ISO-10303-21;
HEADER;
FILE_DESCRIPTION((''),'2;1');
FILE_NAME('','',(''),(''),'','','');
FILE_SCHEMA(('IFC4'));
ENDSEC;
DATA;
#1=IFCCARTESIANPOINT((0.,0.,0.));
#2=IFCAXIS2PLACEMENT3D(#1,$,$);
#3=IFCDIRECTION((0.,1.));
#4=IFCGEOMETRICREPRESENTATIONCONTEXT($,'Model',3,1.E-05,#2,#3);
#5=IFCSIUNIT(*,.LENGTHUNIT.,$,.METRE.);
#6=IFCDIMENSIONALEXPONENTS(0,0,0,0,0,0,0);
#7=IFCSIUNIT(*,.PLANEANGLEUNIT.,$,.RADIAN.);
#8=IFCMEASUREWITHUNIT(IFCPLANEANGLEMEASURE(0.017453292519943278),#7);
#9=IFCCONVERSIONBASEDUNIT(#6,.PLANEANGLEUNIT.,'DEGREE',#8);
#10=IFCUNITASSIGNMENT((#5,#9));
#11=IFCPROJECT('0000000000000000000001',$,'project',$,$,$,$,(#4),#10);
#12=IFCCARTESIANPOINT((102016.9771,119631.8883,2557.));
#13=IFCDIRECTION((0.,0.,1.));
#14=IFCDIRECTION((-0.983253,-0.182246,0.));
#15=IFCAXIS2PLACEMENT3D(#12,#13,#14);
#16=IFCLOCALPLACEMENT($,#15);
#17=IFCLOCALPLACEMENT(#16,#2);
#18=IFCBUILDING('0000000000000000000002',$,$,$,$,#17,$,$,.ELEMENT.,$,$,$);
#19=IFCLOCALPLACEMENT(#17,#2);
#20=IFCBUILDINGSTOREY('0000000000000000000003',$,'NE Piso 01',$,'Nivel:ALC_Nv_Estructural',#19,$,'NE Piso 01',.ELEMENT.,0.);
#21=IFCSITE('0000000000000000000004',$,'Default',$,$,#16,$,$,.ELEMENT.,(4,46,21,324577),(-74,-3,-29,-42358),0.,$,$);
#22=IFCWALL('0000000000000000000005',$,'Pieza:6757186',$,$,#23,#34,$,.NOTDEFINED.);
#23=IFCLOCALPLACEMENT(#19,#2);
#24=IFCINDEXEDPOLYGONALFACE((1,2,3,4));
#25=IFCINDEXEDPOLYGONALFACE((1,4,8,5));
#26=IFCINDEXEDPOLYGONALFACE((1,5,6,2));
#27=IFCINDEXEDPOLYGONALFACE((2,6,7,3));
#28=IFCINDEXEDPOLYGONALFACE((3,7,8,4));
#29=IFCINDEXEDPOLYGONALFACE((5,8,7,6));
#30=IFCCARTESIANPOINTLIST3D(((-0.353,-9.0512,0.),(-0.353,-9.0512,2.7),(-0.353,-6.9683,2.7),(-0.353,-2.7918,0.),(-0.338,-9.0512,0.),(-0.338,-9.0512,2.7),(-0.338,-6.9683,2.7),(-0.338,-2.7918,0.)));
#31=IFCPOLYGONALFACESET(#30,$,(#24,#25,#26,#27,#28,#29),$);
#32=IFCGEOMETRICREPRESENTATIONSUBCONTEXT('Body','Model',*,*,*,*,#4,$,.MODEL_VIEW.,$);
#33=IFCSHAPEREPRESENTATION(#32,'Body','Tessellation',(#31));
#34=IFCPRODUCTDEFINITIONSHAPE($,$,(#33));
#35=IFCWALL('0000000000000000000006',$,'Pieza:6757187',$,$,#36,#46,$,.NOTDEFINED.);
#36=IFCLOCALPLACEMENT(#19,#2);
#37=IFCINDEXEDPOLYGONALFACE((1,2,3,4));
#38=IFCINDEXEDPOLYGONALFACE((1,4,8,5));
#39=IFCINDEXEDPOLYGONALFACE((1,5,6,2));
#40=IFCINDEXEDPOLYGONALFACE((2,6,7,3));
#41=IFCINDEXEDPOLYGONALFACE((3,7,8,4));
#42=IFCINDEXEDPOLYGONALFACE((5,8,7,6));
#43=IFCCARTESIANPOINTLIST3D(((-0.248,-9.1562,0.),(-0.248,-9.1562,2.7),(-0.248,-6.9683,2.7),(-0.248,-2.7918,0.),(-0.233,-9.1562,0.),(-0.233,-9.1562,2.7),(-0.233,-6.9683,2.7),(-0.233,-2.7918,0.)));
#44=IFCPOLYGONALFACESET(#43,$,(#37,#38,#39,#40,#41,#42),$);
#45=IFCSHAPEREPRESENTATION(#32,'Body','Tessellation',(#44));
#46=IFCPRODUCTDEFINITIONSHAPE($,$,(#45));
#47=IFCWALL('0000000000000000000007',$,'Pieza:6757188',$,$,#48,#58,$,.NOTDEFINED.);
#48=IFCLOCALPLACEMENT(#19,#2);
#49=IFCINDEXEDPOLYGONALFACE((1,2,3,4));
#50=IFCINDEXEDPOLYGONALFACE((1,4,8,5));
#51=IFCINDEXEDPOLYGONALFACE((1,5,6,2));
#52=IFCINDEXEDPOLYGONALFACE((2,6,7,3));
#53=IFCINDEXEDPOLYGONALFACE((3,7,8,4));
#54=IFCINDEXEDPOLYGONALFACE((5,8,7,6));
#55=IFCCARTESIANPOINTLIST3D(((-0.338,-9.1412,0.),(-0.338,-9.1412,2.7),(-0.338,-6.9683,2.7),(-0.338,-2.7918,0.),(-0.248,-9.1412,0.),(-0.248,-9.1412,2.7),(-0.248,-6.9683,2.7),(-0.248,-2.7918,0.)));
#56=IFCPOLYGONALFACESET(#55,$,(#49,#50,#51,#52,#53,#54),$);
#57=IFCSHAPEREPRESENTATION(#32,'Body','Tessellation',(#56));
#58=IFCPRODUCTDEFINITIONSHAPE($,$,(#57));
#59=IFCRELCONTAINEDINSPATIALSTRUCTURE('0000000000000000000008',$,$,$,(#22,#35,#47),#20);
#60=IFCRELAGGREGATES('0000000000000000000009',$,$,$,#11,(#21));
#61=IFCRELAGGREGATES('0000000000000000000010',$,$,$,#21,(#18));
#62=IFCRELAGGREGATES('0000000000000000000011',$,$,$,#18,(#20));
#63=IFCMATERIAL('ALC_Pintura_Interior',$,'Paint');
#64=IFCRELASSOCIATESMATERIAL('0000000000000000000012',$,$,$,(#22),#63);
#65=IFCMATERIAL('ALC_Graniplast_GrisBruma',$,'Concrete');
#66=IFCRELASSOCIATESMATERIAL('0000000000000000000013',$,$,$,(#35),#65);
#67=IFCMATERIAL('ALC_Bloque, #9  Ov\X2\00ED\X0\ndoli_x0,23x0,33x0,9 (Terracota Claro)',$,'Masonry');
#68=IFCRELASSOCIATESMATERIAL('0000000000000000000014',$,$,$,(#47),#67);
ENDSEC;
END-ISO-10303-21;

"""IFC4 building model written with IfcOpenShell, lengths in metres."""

from ifc_helpers import new_model, entity, si_unit, converted_unit, direction, frame, frame_2d, origin, origin_2d_with_axis, place, context, subcontext, project, spatial, rectangle, extrude, clip, halfspace, material, element, save


model = new_model("IFC4")

# Units and contexts
model_context = context("Model", 3, precision=1e-05, world=origin(), true_north=direction((0.0, 1.0)))
body_context = subcontext(model_context, "Body", "Model", "MODEL_VIEW")
ifc_project = project(units=[si_unit("LENGTHUNIT", "METRE"), converted_unit("PLANEANGLEUNIT", "DEGREE", entity("IfcPlaneAngleMeasure", 0.017453292519943278), si_unit("PLANEANGLEUNIT", "RADIAN"), dimensions=[0, 0, 0, 0, 0, 0, 0])], contexts=[model_context])

# Site, building, storey
site_placement = place(None, frame((102016.9771, 119631.8883, 2557.0), z_axis=(0.0, 0.0, 1.0), x_axis=(-0.983253, -0.182246, 0.0)))
site = spatial("IfcSite", under=ifc_project, at=site_placement, Name="Default", CompositionType="ELEMENT", RefLatitude=(4, 46, 21, 324577), RefLongitude=(-74, -3, -29, -42358), RefElevation=0.0)
building_placement = place(site_placement, origin())
building = spatial("IfcBuilding", under=site, at=building_placement, CompositionType="ELEMENT")
storey_placement = place(building_placement, origin())
storey = spatial("IfcBuildingStorey", under=building, at=storey_placement, Name="NE Piso 01", ObjectType="Nivel:ALC_Nv_Estructural", LongName="NE Piso 01", CompositionType="ELEMENT", Elevation=0.0)

# Shared definitions
ifc_material_1 = material(Name="ALC_Pintura_Interior", Category="Paint")

# Shared definitions
ifc_material_2 = material(Name="ALC_Bloque, #9  Ovíndoli_x0,23x0,33x0,9 (Terracota Claro)", Category="Masonry")

# Walls
ifc_material_3 = material(Name="ALC_Graniplast_GrisBruma", Category="Concrete")
wall_1_placement = place(storey_placement, origin())
element("IfcWall", 1, at=wall_1_placement, inside=storey, material=ifc_material_1, Name="Pieza:6757186", PredefinedType="NOTDEFINED", context=body_context, shape_type="SweptSolid", body=[
    clip(extrude(rectangle(XDim=0.015, YDim=6.2594, at=frame_2d((0.0, 0.0), x_axis=(1.0, 0.0))), frame((-0.3455, -5.9215, 0.0)), (0.0, 0.0, 1.0), 2.7), halfspace(frame((-0.233, -2.7918, 0.0), z_axis=(0.0, 0.5429, 0.839798), x_axis=(-1.0, 0.0, 0.0)), False)),
])
wall_2_placement = place(storey_placement, origin())
element("IfcWall", 2, at=wall_2_placement, inside=storey, material=ifc_material_3, Name="Pieza:6757187", PredefinedType="NOTDEFINED", context=body_context, shape_type="SweptSolid", body=[
    clip(extrude(rectangle(XDim=0.015, YDim=6.3644, at=origin_2d_with_axis()), frame((-0.2405, -5.974, 0.0)), (0.0, 0.0, 1.0), 2.7), halfspace(frame((-0.233, -2.7918, 0.0), z_axis=(0.0, 0.5429, 0.839798), x_axis=(-1.0, 0.0, 0.0)), False)),
])
wall_3_placement = place(storey_placement, origin())
element("IfcWall", 3, at=wall_3_placement, inside=storey, material=ifc_material_2, Name="Pieza:6757188", PredefinedType="NOTDEFINED", context=body_context, shape_type="SweptSolid", body=[
    clip(extrude(rectangle(XDim=0.09, YDim=6.3494, at=frame_2d((0.0, 0.0), x_axis=(1.0, 0.0))), frame((-0.293, -5.9665, 0.0)), (0.0, 0.0, 1.0), 2.7), halfspace(frame((-0.233, -2.7918, 0.0), z_axis=(0.0, 0.5429, 0.839798), x_axis=(-1.0, 0.0, 0.0)), False)),
])

save(model, "model.ifc")
